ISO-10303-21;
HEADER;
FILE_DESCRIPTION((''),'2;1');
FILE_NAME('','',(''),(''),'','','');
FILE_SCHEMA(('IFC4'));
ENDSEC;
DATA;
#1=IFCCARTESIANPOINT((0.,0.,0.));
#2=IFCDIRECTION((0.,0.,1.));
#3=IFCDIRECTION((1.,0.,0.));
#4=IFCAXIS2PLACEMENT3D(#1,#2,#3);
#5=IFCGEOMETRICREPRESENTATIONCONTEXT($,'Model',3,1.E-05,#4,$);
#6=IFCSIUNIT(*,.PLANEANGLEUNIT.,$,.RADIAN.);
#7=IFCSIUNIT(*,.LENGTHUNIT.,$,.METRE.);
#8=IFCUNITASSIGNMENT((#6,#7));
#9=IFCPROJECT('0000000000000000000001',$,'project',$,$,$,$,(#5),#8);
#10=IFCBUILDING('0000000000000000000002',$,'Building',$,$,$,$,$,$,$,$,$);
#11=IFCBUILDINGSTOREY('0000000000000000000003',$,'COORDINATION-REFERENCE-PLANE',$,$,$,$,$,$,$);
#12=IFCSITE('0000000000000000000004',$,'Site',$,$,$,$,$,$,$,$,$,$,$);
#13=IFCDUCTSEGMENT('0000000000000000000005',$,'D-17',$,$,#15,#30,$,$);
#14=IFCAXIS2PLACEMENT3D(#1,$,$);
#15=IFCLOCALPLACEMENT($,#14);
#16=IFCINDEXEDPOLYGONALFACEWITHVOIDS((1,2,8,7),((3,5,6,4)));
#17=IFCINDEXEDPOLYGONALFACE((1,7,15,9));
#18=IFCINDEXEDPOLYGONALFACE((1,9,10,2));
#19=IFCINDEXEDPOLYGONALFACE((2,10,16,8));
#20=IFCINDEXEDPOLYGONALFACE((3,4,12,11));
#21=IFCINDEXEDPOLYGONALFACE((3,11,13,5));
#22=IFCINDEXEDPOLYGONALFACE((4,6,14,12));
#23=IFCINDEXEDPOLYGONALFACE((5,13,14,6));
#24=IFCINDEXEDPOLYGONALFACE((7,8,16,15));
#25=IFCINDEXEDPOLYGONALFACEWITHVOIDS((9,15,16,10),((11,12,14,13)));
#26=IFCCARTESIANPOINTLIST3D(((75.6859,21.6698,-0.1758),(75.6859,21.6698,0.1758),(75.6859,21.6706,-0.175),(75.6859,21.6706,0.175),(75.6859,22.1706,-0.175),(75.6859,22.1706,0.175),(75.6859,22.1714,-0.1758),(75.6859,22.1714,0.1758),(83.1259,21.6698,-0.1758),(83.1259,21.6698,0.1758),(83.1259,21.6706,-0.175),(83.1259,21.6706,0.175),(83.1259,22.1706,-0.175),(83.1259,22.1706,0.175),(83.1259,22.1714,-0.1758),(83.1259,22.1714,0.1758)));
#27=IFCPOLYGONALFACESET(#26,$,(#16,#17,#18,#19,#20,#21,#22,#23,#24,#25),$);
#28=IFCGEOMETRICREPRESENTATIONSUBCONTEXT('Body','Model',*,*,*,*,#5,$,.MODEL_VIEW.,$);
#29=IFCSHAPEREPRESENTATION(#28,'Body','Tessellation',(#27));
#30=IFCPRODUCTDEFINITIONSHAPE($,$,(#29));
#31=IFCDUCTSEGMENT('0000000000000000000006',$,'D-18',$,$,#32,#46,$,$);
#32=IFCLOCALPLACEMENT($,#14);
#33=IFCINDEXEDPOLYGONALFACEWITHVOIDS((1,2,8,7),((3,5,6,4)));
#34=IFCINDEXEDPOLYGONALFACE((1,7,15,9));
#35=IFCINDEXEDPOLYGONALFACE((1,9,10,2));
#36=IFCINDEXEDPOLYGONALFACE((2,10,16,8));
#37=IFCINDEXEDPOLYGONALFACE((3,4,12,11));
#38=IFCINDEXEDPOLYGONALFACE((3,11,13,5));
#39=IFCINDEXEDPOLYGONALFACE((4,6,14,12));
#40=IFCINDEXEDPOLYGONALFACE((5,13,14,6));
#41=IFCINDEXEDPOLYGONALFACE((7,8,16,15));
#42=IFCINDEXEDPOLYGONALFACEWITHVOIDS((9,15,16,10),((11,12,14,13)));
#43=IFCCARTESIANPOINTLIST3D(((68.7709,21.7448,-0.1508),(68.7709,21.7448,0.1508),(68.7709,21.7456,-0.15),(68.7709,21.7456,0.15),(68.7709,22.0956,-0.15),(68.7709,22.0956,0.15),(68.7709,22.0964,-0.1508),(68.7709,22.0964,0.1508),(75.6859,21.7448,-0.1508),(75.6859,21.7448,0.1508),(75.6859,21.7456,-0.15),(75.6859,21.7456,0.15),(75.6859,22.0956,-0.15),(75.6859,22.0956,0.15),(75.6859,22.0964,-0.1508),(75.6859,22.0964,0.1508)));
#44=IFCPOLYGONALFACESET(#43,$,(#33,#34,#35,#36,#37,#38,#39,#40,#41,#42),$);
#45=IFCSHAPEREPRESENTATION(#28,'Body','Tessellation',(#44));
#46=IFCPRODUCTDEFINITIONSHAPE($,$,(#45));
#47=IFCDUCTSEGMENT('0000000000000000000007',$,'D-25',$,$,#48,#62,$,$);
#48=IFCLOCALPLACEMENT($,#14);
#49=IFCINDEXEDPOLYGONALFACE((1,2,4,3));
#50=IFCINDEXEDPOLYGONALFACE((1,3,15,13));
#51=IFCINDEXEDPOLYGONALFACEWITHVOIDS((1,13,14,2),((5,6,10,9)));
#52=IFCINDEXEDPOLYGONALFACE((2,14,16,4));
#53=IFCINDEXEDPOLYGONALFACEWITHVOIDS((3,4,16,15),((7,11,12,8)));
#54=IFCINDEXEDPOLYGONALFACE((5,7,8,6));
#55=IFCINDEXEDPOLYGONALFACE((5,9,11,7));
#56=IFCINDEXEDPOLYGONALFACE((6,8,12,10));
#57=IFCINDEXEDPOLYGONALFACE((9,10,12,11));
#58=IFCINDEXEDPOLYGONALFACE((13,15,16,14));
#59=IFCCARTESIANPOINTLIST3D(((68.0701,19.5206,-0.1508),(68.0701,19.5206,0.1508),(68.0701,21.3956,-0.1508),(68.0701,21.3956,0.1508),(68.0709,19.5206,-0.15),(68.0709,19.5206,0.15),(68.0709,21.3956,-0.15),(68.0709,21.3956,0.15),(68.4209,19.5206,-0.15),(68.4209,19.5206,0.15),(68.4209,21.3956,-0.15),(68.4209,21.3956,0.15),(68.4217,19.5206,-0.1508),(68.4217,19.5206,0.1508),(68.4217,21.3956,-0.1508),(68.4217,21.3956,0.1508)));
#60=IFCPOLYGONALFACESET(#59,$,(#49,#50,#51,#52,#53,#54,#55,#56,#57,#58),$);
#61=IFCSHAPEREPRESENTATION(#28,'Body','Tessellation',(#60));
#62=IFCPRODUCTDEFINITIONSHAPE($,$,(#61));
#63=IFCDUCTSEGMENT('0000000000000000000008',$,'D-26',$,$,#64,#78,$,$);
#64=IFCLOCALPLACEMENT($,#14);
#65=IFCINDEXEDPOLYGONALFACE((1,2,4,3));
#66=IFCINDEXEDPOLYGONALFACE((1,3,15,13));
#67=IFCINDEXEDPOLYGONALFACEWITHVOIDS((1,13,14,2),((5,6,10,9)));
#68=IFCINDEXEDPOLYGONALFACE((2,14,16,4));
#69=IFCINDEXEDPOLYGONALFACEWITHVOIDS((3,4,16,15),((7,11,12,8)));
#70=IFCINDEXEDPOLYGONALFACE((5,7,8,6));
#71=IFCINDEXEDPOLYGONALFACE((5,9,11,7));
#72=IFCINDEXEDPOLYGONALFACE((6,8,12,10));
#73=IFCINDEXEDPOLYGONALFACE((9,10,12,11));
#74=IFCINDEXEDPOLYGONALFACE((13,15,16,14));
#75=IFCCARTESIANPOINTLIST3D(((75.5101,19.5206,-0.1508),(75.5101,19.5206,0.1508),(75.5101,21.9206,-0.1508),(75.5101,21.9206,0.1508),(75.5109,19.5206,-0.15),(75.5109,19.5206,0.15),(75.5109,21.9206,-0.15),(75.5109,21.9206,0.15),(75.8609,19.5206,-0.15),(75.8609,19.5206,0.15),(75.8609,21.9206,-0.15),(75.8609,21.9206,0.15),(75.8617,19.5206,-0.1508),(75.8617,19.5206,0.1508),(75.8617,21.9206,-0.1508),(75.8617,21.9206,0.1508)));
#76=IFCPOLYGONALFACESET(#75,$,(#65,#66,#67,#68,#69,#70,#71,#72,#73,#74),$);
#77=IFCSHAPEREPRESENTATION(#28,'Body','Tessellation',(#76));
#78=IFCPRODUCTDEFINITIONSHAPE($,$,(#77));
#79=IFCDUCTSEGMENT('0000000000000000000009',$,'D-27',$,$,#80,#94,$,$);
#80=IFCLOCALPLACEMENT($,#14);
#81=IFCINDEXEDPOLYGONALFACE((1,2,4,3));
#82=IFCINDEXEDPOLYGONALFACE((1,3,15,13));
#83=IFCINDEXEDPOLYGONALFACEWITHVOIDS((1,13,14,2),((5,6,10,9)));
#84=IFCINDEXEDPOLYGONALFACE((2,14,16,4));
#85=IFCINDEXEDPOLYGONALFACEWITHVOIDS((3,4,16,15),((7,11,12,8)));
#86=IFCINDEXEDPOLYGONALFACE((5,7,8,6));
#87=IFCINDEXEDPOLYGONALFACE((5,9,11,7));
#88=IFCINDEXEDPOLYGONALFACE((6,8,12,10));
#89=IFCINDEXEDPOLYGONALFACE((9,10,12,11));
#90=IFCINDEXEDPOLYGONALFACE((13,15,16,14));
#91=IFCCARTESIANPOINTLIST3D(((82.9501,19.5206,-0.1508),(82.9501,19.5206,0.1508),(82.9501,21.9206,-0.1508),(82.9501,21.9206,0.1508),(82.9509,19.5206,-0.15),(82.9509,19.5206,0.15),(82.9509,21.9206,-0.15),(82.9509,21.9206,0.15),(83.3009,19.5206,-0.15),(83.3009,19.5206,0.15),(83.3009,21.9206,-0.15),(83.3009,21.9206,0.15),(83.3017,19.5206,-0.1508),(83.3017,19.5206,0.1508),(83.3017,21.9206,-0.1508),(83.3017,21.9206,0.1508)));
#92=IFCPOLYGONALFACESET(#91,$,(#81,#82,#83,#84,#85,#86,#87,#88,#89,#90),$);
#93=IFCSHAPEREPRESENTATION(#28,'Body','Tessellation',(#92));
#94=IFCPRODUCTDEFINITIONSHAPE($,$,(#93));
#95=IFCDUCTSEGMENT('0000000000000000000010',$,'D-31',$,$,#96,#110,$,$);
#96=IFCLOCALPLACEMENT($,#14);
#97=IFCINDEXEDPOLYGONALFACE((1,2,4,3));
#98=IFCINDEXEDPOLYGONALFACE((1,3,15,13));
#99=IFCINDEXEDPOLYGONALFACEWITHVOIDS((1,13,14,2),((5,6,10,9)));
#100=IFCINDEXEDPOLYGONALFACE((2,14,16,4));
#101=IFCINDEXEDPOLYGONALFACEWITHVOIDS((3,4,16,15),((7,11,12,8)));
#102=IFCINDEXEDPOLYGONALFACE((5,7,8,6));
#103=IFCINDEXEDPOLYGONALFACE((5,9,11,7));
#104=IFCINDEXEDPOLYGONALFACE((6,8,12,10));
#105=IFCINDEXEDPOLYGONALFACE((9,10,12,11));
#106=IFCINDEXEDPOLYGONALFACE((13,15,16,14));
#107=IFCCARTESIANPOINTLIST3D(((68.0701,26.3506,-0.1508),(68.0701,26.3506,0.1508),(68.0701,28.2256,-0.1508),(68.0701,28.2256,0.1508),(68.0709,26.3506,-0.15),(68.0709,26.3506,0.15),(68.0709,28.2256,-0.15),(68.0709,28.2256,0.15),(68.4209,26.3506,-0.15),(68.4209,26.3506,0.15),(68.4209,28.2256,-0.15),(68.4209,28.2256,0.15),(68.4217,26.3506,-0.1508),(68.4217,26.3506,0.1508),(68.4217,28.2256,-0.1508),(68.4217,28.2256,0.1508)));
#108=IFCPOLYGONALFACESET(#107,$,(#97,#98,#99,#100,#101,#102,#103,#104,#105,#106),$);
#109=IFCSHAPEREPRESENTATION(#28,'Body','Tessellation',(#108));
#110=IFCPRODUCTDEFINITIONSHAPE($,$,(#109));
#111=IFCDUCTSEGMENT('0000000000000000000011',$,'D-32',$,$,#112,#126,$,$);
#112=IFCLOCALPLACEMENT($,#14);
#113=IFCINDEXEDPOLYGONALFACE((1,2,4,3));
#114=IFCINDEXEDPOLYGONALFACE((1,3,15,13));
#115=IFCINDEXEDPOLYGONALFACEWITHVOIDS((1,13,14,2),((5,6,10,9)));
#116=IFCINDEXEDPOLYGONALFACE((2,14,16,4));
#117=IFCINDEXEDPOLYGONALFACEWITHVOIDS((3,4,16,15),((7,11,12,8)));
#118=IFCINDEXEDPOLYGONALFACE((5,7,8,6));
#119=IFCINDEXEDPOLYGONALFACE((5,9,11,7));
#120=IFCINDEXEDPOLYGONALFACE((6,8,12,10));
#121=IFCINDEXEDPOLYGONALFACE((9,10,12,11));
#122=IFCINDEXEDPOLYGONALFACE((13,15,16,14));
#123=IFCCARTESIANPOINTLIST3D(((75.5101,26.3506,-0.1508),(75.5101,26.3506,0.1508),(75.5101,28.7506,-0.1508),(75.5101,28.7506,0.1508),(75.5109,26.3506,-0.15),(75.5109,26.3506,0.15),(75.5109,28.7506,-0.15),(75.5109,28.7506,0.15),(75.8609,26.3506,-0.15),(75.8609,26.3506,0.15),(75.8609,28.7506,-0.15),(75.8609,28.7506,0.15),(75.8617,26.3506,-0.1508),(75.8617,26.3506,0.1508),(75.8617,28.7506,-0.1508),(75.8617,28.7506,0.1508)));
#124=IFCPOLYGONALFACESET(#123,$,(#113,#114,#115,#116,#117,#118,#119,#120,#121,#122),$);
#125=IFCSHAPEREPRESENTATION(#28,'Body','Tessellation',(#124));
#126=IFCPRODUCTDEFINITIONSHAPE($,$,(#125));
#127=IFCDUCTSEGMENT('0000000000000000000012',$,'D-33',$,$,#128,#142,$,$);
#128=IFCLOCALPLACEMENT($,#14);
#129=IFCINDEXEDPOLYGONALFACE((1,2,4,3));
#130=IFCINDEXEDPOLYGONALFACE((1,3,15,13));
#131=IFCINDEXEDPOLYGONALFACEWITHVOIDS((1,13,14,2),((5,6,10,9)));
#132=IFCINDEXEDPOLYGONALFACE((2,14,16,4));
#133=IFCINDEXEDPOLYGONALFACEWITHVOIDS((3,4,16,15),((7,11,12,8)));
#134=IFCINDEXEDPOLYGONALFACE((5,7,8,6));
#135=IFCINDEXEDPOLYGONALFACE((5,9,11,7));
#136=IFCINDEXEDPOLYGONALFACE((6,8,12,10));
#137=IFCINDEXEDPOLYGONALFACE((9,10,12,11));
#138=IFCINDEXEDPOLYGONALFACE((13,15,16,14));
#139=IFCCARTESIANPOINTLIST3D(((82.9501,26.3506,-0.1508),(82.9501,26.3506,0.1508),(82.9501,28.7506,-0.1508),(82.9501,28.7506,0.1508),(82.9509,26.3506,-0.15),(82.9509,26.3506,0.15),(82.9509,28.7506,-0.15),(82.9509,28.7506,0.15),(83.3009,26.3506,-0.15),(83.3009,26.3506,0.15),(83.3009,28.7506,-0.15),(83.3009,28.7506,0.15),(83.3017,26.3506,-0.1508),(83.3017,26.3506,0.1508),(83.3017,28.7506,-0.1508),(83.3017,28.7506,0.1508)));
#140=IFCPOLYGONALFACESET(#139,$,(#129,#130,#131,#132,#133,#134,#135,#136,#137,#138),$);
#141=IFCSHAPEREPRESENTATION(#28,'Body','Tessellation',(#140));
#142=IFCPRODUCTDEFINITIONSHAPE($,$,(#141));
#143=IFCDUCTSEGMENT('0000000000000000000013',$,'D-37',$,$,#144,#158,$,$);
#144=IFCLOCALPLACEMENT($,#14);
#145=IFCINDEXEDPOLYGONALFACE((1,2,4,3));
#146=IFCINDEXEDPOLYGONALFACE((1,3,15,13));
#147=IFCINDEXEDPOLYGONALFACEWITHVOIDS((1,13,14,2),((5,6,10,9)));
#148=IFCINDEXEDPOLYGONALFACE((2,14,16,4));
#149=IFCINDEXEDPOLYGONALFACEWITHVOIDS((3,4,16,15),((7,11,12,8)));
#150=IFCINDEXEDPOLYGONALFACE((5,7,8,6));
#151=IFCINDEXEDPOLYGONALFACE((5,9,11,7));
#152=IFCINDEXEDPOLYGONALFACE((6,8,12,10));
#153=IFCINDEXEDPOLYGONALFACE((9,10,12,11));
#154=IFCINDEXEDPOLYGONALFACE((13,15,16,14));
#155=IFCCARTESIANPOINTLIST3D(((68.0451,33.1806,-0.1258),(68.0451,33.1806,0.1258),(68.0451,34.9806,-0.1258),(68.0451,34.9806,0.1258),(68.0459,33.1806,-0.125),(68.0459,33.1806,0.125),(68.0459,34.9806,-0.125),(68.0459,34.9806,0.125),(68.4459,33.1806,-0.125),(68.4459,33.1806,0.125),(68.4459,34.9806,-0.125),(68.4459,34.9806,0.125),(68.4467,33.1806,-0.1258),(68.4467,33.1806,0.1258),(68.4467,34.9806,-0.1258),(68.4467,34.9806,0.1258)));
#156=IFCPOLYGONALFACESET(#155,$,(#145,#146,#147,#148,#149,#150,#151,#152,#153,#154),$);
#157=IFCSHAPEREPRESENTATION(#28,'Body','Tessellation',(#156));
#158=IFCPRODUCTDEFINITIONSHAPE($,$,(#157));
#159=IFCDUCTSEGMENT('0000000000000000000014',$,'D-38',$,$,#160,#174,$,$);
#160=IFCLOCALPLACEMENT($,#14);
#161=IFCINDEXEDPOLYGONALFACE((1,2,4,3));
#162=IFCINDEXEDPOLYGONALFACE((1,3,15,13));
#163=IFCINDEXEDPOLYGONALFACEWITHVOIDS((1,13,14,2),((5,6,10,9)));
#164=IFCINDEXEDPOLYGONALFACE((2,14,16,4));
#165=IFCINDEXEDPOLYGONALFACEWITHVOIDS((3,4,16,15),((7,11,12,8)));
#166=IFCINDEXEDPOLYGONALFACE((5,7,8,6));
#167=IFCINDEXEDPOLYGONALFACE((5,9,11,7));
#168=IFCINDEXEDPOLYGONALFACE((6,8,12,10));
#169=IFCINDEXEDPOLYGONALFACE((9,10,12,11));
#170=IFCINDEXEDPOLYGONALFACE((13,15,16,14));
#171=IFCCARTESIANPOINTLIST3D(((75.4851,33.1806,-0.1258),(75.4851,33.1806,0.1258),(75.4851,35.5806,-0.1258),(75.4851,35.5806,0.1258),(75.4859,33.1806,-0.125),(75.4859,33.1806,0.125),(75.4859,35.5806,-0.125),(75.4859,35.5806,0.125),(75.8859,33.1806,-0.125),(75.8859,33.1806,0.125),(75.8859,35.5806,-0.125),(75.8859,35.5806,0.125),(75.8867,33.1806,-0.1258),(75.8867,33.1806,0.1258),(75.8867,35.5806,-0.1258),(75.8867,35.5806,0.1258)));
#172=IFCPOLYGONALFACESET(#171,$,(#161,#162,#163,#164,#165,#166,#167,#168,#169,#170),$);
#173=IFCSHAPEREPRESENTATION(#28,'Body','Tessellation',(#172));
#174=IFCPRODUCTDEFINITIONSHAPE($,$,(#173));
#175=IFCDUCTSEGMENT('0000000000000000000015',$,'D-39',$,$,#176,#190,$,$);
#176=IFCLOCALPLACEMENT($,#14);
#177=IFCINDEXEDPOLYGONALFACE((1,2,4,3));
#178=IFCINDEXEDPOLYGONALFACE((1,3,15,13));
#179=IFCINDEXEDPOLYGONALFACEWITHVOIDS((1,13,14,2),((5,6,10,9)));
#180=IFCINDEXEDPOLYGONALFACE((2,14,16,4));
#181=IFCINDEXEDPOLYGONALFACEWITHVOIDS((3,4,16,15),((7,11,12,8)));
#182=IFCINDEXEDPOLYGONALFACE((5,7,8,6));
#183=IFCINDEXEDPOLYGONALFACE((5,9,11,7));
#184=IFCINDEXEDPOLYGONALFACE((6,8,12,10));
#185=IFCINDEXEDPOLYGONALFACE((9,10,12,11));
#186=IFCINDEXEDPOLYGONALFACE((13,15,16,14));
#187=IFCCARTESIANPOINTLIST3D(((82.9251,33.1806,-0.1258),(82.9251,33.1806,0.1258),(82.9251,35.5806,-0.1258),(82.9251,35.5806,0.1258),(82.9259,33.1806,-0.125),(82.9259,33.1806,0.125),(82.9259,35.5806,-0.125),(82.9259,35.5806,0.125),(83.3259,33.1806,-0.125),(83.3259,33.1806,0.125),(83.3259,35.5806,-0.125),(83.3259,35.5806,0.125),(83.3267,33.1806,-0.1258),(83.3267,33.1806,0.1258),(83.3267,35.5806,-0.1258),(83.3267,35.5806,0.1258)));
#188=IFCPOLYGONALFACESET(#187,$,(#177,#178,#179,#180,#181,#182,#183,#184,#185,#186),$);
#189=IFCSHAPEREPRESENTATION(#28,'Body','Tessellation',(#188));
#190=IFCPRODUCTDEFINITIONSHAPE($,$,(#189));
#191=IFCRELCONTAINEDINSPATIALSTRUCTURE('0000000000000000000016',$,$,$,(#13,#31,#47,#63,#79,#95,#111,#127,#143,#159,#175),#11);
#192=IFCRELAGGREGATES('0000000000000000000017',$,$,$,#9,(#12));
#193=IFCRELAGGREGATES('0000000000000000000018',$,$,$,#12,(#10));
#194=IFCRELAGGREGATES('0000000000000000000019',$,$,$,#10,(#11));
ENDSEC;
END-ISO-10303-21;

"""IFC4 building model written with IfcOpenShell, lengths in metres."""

from ifc_helpers import new_model, si_unit, frame, origin, origin_with_axes, place, context, subcontext, project, spatial, hollow_rectangle, extrude, element, save


model = new_model("IFC4")

# Units and contexts
model_context = context("Model", 3, precision=1e-05, world=origin_with_axes())
body_context = subcontext(model_context, "Body", "Model", "MODEL_VIEW")
ifc_project = project(units=[si_unit("PLANEANGLEUNIT", "RADIAN"), si_unit("LENGTHUNIT", "METRE")], contexts=[model_context])

# Site, building, storey
site = spatial("IfcSite", under=ifc_project, Name="Site")
building = spatial("IfcBuilding", under=site, Name="Building")
storey = spatial("IfcBuildingStorey", under=building, Name="COORDINATION-REFERENCE-PLANE")

# Duct segments
duct_segment_1_placement = place(None, frame((75.6859, 21.9206, 0.0), z_axis=(1.0, 0.0, 0.0), x_axis=(0.0, 1.0, 0.0)))
element("IfcDuctSegment", 1, at=duct_segment_1_placement, inside=storey, Name="D-17", context=body_context, shape_type="SweptSolid", body=[
    extrude(hollow_rectangle(XDim=0.5016, YDim=0.3516, WallThickness=0.0008), origin(), (0.0, 0.0, 1.0), 7.44),
])
duct_segment_2_placement = place(None, frame((68.7709, 21.9206, 0.0), z_axis=(1.0, 0.0, 0.0), x_axis=(0.0, 1.0, 0.0)))
element("IfcDuctSegment", 2, at=duct_segment_2_placement, inside=storey, Name="D-18", context=body_context, shape_type="SweptSolid", body=[
    extrude(hollow_rectangle(XDim=0.3516, YDim=0.3016, WallThickness=0.0008), origin(), (0.0, 0.0, 1.0), 6.915),
])
duct_segment_3_placement = place(None, frame((68.2459, 19.5206, 0.0), z_axis=(0.0, 1.0, 0.0), x_axis=(1.0, 0.0, 0.0)))
element("IfcDuctSegment", 3, at=duct_segment_3_placement, inside=storey, Name="D-25", context=body_context, shape_type="SweptSolid", body=[
    extrude(hollow_rectangle(XDim=0.3516, YDim=0.3016, WallThickness=0.0008), origin(), (0.0, 0.0, 1.0), 1.875),
])
for number, where, z_axis, x_axis, name in (
    (4, (75.6859, 19.5206, 0.0), (0.0, 1.0, 0.0), (1.0, 0.0, 0.0), "D-26"),
    (5, (83.1259, 19.5206, 0.0), (0.0, 1.0, 0.0), (1.0, 0.0, 0.0), "D-27"),
):
    element("IfcDuctSegment", number, at=place(None, frame(where, z_axis=z_axis, x_axis=x_axis)), inside=storey, Name=name, context=body_context, shape_type="SweptSolid", body=[
        extrude(hollow_rectangle(XDim=0.3516, YDim=0.3016, WallThickness=0.0008), origin(), (0.0, 0.0, 1.0), 2.4),
    ])
duct_segment_4_placement = place(None, frame((68.2459, 26.3506, 0.0), z_axis=(0.0, 1.0, 0.0), x_axis=(1.0, 0.0, 0.0)))
element("IfcDuctSegment", 6, at=duct_segment_4_placement, inside=storey, Name="D-31", context=body_context, shape_type="SweptSolid", body=[
    extrude(hollow_rectangle(XDim=0.3516, YDim=0.3016, WallThickness=0.0008), origin(), (0.0, 0.0, 1.0), 1.875),
])
for number, where, z_axis, x_axis, name in (
    (7, (75.6859, 26.3506, 0.0), (0.0, 1.0, 0.0), (1.0, 0.0, 0.0), "D-32"),
    (8, (83.1259, 26.3506, 0.0), (0.0, 1.0, 0.0), (1.0, 0.0, 0.0), "D-33"),
):
    element("IfcDuctSegment", number, at=place(None, frame(where, z_axis=z_axis, x_axis=x_axis)), inside=storey, Name=name, context=body_context, shape_type="SweptSolid", body=[
        extrude(hollow_rectangle(XDim=0.3516, YDim=0.3016, WallThickness=0.0008), origin(), (0.0, 0.0, 1.0), 2.4),
    ])
duct_segment_5_placement = place(None, frame((68.2459, 33.1806, 0.0), z_axis=(0.0, 1.0, 0.0), x_axis=(1.0, 0.0, 0.0)))
element("IfcDuctSegment", 9, at=duct_segment_5_placement, inside=storey, Name="D-37", context=body_context, shape_type="SweptSolid", body=[
    extrude(hollow_rectangle(XDim=0.4016, YDim=0.2516, WallThickness=0.0008), origin(), (0.0, 0.0, 1.0), 1.8),
])
for number, where, z_axis, x_axis, name in (
    (10, (75.6859, 33.1806, 0.0), (0.0, 1.0, 0.0), (1.0, 0.0, 0.0), "D-38"),
    (11, (83.1259, 33.1806, 0.0), (0.0, 1.0, 0.0), (1.0, 0.0, 0.0), "D-39"),
):
    element("IfcDuctSegment", number, at=place(None, frame(where, z_axis=z_axis, x_axis=x_axis)), inside=storey, Name=name, context=body_context, shape_type="SweptSolid", body=[
        extrude(hollow_rectangle(XDim=0.4016, YDim=0.2516, WallThickness=0.0008), origin(), (0.0, 0.0, 1.0), 2.4),
    ])

save(model, "model.ifc")
